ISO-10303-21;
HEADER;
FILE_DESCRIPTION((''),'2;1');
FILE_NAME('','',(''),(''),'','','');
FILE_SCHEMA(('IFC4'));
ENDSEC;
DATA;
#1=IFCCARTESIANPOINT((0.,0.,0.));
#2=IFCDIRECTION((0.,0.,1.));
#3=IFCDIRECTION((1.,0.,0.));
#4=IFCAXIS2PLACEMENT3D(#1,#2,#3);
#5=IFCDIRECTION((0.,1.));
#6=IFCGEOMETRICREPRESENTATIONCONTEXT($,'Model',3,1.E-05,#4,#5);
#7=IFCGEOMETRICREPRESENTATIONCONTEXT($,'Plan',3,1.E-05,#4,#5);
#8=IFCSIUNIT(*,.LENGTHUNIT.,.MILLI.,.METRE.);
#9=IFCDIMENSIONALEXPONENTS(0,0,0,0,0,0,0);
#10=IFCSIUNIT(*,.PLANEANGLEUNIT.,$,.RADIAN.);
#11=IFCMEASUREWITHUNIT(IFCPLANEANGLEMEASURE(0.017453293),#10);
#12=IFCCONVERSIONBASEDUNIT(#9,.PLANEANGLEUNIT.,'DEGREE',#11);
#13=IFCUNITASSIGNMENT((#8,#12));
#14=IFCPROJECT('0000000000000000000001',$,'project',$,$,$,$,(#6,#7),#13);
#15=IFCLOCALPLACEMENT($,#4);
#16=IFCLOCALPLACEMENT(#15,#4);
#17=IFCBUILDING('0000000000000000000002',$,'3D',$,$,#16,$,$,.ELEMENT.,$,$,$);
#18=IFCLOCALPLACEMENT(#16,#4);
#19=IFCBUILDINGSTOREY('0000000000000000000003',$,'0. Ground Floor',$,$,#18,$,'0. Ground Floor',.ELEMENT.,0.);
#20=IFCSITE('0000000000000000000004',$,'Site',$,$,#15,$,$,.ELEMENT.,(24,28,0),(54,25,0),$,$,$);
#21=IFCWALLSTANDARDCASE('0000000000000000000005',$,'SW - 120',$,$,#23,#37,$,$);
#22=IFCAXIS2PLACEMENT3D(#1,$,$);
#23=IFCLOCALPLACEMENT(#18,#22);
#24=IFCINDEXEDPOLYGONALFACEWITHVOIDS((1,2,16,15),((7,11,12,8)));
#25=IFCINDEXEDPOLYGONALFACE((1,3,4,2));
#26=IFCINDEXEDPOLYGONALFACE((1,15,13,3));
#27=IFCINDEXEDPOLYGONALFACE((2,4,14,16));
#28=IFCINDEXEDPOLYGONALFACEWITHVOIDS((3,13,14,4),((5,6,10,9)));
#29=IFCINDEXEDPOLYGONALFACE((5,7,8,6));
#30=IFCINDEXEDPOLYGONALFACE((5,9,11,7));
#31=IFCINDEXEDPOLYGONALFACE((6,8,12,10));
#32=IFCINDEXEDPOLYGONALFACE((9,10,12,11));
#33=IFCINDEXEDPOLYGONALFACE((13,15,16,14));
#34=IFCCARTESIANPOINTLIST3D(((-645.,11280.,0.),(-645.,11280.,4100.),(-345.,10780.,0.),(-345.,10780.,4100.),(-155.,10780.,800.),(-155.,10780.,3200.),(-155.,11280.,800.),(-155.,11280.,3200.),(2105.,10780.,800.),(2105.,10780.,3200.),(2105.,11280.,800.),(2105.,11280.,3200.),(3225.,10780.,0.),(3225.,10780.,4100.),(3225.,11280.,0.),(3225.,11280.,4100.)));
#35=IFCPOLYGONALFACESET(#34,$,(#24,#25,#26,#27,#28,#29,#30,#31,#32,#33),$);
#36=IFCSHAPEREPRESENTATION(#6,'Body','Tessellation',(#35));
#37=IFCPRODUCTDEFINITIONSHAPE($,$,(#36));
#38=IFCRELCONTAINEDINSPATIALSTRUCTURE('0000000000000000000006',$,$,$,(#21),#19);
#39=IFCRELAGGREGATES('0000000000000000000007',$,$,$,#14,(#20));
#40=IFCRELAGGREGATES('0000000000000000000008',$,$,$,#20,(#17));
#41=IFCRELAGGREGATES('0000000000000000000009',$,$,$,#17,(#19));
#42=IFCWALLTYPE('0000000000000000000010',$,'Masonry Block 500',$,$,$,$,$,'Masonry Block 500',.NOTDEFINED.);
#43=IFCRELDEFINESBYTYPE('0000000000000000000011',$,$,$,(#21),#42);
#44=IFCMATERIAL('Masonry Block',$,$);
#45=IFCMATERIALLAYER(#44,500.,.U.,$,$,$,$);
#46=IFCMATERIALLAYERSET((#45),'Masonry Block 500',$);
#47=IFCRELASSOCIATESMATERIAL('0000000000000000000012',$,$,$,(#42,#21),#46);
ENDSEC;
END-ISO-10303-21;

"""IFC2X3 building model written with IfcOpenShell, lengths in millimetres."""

from ifc_helpers import new_model, entity, si_unit, converted_unit, direction, frame, frame_2d, origin_with_axes, place, context, project, spatial, polyline, rectangle, outline, extrude, material, layer, layer_set, layer_usage, type_object, element, save


model = new_model("IFC2X3")

# Units and contexts
model_context = context("Model", 3, precision=1e-05, world=origin_with_axes(), true_north=direction((0.0, 1.0)))
plan_context = context("Plan", 3, precision=1e-05, world=origin_with_axes(), true_north=direction((0.0, 1.0)))
ifc_project = project(units=[si_unit("LENGTHUNIT", "METRE", prefix="MILLI"), converted_unit("PLANEANGLEUNIT", "DEGREE", entity("IfcPlaneAngleMeasure", 0.017453293), si_unit("PLANEANGLEUNIT", "RADIAN"), dimensions=[0, 0, 0, 0, 0, 0, 0])], contexts=[model_context, plan_context])

# Site, building, storey
site_placement = place(None, origin_with_axes())
site = spatial("IfcSite", under=ifc_project, at=site_placement, Name="Site", CompositionType="ELEMENT", RefLatitude=(24, 28, 0), RefLongitude=(54, 25, 0))
building_placement = place(site_placement, origin_with_axes())
building = spatial("IfcBuilding", under=site, at=building_placement, Name="3D", CompositionType="ELEMENT")
storey_placement = place(building_placement, origin_with_axes())
storey = spatial("IfcBuildingStorey", under=building, at=storey_placement, Name="0. Ground Floor", LongName="0. Ground Floor", CompositionType="ELEMENT", Elevation=0.0)

# Shared definitions
ifc_material_1 = material(Name="Masonry Block")

# Shared definitions
ifc_layer_1 = layer(ifc_material_1, 500.0, ventilated="UNKNOWN")
ifc_layer_set_1 = layer_set([ifc_layer_1], Name="Masonry Block 500")
wall_type_1 = type_object("IfcWallType", Name="Masonry Block 500", ElementType="Masonry Block 500", PredefinedType="NOTDEFINED", material=ifc_layer_set_1)

# Wall, opening
ifc_layer_usage_1 = layer_usage(ifc_layer_set_1, "AXIS2", "NEGATIVE", 0.0)
wall_1_placement = place(storey_placement, frame((-645.0, 11280.0, 0.0), z_axis=(0.0, 0.0, 1.0), x_axis=(1.0, 0.0, 0.0)))
wall_1 = element("IfcWallStandardCase", 1, at=wall_1_placement, inside=storey, type_object=wall_type_1, material=ifc_layer_usage_1, Name="SW - 120", context=model_context, shape_type="SweptSolid", body=[
    extrude(outline(polyline([(300.0, -500.0), (3870.0, -500.0), (3870.0, 0.0), (0.0, 0.0), (300.0, -500.0)])), origin_with_axes(), (0.0, 0.0, 1.0), 4100.0),
])
opening_1_placement = place(wall_1_placement, frame((1620.0, -500.0, 800.0), z_axis=(0.0, 0.0, 1.0), x_axis=(1.0, 0.0, 0.0)))
element("IfcOpeningElement", 2, at=opening_1_placement, cuts=wall_1, ObjectType="Opening", context=model_context, shape_type="SweptSolid", body=[
    extrude(rectangle(XDim=2260.0, YDim=2400.0, at=frame_2d((0.0, 1200.0), x_axis=(1.0, 0.0))), frame((0.0, 0.0, 0.0), z_axis=(0.0, 1.0, 0.0), x_axis=(-1.0, 0.0, 0.0)), (0.0, 0.0, 1.0), 500.0),
])

save(model, "model.ifc")
